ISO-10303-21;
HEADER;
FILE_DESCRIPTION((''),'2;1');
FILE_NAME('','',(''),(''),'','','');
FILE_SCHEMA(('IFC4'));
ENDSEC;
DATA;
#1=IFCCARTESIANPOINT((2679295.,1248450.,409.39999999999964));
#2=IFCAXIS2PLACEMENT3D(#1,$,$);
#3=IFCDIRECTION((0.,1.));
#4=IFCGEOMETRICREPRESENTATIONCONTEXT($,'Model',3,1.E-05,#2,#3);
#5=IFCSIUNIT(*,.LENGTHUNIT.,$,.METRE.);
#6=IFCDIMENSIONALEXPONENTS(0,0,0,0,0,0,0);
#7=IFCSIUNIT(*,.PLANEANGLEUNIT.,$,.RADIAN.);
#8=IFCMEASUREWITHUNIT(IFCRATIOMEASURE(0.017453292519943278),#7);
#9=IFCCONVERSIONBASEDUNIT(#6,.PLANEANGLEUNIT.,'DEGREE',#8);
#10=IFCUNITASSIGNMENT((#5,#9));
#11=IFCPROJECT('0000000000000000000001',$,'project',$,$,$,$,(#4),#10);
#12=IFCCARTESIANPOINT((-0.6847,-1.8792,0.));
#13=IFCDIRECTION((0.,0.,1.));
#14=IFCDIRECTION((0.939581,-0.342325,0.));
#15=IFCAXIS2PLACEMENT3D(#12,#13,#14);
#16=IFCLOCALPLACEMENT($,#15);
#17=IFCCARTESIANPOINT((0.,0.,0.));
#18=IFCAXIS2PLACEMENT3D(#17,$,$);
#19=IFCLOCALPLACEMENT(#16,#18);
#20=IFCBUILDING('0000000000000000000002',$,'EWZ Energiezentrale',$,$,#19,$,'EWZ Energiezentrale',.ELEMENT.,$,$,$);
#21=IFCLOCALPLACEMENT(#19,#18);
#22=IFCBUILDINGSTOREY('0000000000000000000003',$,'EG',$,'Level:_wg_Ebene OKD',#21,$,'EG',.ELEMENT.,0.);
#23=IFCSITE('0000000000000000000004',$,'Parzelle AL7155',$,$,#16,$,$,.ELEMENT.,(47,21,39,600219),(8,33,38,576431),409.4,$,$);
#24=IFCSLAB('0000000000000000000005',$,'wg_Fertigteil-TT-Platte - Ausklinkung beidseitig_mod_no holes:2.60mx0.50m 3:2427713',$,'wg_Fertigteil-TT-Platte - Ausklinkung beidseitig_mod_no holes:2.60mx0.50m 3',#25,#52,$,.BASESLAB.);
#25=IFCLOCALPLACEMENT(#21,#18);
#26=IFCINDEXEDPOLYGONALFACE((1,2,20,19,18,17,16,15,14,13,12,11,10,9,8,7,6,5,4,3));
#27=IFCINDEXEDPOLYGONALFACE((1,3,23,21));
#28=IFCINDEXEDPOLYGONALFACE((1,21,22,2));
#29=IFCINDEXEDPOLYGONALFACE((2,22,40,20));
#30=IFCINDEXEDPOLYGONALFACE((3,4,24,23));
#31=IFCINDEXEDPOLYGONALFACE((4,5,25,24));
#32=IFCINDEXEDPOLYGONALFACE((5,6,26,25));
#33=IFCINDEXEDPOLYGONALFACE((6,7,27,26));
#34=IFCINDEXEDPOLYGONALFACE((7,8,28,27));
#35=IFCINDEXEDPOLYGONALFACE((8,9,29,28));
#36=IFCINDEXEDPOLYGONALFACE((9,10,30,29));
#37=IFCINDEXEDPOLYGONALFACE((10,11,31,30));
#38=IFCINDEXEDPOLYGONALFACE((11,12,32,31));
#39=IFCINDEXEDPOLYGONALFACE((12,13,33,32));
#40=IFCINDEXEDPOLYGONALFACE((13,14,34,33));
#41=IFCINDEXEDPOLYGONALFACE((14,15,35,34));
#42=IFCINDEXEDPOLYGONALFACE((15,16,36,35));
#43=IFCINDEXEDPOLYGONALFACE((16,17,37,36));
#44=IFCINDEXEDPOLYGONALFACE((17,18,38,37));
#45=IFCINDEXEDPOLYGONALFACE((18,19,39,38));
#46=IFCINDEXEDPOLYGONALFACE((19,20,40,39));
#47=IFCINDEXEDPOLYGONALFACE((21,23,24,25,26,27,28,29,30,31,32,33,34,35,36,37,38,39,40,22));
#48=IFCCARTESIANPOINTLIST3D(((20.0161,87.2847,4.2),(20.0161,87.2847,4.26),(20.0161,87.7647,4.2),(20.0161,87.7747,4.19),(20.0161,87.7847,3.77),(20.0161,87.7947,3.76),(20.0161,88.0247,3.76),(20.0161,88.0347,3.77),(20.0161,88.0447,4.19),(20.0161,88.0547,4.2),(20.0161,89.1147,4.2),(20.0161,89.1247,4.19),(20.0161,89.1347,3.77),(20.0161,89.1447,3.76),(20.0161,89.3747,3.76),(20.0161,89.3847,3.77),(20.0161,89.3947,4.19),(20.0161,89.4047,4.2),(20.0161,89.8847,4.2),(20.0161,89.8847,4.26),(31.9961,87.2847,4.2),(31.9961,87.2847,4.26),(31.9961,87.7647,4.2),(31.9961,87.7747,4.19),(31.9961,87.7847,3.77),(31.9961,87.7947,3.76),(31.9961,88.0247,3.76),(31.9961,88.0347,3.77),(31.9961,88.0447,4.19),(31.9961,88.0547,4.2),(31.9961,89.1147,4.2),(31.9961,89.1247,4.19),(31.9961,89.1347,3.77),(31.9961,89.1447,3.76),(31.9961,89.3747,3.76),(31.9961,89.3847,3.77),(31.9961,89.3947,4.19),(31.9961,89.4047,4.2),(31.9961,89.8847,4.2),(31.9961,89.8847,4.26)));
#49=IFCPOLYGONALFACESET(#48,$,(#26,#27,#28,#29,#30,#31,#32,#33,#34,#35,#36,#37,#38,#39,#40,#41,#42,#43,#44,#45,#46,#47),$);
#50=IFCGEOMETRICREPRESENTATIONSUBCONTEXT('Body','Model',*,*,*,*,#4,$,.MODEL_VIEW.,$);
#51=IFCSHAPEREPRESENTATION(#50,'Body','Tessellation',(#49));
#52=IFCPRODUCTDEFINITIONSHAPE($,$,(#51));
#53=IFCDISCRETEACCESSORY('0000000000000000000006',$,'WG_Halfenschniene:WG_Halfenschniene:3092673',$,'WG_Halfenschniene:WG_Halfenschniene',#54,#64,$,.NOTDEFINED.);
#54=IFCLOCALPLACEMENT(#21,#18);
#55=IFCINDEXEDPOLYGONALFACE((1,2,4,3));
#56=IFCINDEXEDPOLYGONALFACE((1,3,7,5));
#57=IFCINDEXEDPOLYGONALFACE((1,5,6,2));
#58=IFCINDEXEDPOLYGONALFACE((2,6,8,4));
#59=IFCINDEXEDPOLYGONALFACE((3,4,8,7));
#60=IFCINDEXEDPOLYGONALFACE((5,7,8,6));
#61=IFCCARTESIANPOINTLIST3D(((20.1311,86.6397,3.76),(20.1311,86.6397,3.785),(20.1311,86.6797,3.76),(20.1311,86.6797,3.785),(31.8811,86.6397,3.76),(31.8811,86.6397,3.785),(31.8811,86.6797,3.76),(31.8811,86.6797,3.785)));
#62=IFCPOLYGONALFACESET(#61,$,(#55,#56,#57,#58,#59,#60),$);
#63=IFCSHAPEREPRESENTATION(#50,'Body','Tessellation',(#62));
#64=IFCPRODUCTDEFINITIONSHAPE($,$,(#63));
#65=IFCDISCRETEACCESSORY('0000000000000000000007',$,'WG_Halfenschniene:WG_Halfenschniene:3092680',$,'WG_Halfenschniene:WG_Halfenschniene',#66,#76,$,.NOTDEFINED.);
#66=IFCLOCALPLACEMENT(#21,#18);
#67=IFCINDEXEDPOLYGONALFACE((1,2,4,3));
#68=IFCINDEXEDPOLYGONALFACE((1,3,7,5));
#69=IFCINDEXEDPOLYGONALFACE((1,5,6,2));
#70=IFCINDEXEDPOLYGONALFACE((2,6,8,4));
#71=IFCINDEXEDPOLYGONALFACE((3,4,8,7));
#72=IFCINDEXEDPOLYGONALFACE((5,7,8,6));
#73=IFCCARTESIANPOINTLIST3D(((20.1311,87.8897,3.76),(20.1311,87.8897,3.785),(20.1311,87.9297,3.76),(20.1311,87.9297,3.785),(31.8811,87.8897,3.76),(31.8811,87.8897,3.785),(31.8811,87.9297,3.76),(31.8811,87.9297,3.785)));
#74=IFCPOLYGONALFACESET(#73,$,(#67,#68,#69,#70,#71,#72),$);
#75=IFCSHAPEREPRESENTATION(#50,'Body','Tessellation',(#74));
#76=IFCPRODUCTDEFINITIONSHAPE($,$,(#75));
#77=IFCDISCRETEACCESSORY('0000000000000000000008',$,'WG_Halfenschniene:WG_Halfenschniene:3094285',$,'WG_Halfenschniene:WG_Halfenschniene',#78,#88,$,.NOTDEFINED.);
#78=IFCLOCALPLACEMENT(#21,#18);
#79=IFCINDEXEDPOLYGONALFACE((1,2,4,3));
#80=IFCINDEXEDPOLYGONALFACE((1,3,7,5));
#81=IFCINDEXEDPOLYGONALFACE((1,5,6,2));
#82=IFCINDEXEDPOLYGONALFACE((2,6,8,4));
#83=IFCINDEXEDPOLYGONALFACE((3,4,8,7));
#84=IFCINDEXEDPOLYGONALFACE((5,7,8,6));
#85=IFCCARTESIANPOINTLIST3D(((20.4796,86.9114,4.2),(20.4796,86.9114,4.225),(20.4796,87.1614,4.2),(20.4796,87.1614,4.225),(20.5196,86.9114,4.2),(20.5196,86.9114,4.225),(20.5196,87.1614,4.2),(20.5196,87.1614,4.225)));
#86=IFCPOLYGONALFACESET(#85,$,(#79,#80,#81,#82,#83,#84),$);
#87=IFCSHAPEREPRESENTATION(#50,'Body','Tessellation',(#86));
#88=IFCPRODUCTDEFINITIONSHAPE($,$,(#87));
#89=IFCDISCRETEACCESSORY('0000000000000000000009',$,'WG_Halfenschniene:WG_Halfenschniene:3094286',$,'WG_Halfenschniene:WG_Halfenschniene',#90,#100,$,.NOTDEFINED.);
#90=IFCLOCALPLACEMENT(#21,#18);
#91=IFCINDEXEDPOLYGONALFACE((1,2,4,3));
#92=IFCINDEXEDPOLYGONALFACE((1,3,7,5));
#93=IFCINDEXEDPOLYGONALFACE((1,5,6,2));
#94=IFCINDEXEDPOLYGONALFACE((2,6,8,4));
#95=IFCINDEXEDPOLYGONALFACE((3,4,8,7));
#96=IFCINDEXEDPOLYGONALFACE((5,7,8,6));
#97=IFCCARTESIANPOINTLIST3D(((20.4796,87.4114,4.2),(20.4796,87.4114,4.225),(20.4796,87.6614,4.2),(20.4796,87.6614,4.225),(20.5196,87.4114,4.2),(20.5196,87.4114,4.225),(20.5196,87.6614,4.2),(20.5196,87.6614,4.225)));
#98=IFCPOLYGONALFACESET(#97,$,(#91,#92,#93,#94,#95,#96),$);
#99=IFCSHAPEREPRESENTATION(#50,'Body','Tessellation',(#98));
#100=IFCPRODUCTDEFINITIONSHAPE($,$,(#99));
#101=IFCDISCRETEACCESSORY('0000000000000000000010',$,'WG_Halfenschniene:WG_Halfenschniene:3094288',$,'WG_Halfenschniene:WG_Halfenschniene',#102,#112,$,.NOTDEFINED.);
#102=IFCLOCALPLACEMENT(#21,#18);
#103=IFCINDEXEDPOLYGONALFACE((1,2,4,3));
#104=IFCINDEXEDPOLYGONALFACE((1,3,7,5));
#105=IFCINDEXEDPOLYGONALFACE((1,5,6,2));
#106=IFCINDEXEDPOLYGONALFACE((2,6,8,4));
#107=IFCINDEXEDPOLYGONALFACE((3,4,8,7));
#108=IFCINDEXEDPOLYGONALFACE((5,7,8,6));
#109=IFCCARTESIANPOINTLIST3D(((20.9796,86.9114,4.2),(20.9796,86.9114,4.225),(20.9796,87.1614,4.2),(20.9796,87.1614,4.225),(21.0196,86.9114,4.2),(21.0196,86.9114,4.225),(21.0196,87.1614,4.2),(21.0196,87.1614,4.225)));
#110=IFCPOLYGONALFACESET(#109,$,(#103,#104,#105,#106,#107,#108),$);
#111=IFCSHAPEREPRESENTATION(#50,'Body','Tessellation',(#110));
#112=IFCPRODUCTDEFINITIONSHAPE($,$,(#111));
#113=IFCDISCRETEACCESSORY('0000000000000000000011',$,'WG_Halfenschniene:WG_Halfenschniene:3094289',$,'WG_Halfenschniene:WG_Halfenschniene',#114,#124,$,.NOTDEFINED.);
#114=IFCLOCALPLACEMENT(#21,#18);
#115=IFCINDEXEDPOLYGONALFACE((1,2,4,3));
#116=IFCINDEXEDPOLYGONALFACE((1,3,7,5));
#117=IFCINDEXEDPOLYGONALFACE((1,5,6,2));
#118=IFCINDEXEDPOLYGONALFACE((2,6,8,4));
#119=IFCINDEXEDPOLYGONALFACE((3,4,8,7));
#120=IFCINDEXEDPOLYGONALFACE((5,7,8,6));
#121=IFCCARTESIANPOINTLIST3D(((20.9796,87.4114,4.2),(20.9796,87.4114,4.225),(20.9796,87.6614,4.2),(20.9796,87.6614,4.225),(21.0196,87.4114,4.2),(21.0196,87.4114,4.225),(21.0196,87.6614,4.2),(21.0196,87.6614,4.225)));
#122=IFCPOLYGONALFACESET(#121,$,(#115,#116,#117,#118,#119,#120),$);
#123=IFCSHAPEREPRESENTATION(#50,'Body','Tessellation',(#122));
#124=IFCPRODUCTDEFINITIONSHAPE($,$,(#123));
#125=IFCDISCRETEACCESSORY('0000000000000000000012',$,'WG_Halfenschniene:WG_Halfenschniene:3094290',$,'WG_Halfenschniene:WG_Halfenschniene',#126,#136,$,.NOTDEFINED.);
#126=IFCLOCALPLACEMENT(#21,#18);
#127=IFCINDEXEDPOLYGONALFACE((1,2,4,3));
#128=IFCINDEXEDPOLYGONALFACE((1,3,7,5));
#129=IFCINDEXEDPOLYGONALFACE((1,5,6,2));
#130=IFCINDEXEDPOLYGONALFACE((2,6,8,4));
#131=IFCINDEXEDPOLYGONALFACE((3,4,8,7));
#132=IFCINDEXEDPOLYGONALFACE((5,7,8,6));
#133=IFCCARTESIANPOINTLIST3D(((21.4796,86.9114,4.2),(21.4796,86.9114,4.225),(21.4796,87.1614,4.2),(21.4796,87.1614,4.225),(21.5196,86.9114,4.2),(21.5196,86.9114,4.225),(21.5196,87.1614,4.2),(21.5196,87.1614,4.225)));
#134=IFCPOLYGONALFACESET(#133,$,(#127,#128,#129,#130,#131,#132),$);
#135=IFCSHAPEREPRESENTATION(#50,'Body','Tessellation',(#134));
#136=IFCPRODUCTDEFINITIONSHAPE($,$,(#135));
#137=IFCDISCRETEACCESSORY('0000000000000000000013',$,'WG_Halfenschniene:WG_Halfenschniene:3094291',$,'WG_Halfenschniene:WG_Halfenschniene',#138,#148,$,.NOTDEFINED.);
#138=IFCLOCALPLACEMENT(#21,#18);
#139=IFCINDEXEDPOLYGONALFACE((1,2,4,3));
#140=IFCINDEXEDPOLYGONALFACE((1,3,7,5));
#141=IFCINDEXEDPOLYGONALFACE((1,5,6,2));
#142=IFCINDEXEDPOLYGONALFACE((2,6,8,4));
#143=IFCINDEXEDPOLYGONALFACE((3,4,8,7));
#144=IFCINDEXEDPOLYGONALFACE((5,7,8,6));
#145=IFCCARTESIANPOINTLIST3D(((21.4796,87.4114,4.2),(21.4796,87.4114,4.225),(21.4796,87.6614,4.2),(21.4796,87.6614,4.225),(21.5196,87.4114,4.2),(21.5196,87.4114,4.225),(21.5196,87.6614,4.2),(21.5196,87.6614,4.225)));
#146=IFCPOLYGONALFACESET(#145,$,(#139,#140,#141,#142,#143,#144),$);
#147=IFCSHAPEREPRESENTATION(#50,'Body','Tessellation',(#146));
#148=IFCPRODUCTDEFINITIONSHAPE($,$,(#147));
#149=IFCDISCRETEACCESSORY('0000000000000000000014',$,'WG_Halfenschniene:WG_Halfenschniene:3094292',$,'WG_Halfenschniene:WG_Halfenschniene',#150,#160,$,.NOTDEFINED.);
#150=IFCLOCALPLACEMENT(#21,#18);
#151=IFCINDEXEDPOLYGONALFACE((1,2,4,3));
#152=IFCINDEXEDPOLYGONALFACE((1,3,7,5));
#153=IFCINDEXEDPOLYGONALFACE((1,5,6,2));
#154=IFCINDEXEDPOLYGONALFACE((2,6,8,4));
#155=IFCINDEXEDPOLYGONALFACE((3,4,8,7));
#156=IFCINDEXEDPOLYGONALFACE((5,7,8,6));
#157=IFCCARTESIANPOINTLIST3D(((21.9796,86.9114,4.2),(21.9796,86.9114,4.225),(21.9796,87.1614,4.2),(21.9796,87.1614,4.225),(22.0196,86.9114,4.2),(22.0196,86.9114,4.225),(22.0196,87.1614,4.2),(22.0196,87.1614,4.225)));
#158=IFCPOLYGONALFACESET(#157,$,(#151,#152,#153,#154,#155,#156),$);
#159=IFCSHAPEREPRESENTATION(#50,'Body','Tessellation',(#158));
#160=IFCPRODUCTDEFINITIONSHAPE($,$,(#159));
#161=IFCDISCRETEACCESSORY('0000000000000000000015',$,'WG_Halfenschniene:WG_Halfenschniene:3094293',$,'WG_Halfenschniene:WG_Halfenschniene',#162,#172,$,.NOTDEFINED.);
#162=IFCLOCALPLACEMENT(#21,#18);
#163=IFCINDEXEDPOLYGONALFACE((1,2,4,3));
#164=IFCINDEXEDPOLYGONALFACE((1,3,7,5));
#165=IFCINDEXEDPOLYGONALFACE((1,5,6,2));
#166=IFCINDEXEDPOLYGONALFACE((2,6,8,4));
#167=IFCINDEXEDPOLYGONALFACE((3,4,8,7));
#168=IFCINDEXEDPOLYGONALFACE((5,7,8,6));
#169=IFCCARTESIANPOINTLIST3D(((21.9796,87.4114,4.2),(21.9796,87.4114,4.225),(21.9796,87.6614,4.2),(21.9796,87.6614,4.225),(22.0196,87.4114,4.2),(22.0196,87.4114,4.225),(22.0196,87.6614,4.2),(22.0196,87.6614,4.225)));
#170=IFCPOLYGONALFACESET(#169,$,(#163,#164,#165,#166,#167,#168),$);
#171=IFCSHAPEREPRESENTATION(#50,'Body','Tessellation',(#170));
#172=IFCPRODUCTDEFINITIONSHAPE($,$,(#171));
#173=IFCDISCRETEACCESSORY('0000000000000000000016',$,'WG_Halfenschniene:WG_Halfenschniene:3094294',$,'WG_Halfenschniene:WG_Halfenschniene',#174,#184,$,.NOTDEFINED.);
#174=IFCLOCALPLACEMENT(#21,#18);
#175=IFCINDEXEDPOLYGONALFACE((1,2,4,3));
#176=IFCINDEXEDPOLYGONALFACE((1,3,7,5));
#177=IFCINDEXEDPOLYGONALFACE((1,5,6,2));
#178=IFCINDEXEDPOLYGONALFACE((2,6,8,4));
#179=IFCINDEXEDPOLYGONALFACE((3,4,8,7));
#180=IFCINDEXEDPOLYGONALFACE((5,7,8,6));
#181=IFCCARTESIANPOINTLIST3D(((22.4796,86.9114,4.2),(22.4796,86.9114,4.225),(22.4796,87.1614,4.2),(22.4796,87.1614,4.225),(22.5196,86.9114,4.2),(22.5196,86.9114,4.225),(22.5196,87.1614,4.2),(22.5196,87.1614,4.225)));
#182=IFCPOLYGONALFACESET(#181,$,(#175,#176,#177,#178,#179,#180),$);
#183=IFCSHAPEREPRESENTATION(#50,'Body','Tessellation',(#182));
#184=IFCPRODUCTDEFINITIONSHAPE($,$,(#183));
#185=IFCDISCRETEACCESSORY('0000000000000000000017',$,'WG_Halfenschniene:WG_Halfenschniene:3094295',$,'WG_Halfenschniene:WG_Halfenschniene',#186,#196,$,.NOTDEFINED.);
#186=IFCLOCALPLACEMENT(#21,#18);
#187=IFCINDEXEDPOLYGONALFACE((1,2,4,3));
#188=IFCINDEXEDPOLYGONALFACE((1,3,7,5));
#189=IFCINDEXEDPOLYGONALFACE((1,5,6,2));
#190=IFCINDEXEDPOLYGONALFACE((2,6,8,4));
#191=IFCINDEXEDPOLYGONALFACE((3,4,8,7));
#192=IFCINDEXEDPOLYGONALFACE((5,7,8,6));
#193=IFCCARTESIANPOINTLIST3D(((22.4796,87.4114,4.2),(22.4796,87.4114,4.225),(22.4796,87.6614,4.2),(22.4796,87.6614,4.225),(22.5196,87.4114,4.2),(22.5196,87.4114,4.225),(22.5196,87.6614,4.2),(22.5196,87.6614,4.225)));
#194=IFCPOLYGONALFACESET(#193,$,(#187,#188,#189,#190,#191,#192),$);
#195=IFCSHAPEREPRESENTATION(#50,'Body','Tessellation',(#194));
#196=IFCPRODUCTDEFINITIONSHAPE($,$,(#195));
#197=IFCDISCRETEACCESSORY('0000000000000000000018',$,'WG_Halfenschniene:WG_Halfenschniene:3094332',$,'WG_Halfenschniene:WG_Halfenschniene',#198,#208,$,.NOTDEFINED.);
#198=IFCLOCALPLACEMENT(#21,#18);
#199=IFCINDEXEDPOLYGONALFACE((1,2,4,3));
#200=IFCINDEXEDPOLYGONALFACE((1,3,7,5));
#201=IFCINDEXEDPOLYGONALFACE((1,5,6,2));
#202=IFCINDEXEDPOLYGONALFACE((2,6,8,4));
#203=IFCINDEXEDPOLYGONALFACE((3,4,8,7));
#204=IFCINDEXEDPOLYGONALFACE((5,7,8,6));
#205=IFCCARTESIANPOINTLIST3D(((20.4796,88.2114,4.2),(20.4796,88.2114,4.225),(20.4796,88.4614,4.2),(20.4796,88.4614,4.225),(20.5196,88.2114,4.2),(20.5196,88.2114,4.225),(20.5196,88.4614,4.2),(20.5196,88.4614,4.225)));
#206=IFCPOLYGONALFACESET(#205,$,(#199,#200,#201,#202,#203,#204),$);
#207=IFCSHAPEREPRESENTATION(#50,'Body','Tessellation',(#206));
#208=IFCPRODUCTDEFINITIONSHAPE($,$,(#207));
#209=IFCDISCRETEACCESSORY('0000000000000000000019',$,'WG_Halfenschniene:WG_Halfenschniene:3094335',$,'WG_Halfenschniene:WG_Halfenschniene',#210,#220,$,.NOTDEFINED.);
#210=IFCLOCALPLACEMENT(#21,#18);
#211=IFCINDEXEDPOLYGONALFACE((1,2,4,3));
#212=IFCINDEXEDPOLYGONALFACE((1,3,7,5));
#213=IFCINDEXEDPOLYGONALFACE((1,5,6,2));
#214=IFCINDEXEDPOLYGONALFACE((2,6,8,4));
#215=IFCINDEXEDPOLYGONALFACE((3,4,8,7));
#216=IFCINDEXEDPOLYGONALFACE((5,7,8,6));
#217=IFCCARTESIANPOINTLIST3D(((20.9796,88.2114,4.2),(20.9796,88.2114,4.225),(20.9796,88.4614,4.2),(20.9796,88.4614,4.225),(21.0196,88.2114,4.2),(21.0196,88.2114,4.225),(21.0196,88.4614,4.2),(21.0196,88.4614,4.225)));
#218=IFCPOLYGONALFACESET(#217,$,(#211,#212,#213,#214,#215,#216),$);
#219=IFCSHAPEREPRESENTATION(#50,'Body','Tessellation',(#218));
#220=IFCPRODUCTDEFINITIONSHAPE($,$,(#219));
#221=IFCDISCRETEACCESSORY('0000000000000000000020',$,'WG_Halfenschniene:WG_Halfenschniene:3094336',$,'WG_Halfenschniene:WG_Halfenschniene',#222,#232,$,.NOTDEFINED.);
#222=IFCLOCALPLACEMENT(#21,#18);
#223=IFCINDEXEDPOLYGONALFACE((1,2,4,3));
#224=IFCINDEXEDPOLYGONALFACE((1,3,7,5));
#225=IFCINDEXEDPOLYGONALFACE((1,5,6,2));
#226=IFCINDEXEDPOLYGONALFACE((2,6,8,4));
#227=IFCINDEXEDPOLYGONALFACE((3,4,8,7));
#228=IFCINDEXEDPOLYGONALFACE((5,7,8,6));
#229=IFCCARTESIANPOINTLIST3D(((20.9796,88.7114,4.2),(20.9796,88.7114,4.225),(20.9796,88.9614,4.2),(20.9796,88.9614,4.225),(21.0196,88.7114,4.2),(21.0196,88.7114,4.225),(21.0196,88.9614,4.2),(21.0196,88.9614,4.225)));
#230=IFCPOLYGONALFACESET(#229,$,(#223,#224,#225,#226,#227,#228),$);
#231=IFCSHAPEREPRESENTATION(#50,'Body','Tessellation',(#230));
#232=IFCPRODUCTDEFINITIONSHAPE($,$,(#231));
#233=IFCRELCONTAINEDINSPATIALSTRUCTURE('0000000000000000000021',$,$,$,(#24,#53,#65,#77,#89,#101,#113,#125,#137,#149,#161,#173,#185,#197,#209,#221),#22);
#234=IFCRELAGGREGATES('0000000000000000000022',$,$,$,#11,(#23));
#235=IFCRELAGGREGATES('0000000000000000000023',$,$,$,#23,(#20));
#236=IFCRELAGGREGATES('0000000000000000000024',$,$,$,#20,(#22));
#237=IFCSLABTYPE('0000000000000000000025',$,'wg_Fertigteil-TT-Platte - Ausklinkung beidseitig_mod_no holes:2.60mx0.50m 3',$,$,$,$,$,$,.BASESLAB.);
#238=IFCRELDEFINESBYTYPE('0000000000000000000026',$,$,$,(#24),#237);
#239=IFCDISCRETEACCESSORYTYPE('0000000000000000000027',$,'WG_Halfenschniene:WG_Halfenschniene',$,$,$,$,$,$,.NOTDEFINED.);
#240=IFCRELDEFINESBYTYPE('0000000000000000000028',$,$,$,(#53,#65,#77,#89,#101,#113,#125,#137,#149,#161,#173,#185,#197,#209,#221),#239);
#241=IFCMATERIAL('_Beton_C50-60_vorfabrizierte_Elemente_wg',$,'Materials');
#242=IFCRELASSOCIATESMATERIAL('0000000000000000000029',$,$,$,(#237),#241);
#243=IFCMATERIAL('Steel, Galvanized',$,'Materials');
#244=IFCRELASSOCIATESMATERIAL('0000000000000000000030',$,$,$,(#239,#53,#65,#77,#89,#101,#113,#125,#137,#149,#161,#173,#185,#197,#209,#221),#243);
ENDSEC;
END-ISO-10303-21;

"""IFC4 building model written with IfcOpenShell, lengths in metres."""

from ifc_helpers import new_model, entity, si_unit, converted_unit, direction, frame, origin, place, context, subcontext, project, spatial, indexed_curve, outline, extrude, source, transform, mapped, material, type_object, type_shapes, element, save


model = new_model("IFC4")

# Units and contexts
model_context = context("Model", 3, precision=1e-05, world=frame((2679295.0, 1248450.0, 409.39999999999964)), true_north=direction((0.0, 1.0)))
body_context = subcontext(model_context, "Body", "Model", "MODEL_VIEW")
ifc_project = project(units=[si_unit("LENGTHUNIT", "METRE"), converted_unit("PLANEANGLEUNIT", "DEGREE", entity("IfcRatioMeasure", 0.017453292519943278), si_unit("PLANEANGLEUNIT", "RADIAN"), dimensions=[0, 0, 0, 0, 0, 0, 0])], contexts=[model_context])

# Site, building, storey
site_placement = place(None, frame((-0.6847, -1.8792, 0.0), z_axis=(0.0, 0.0, 1.0), x_axis=(0.939581, -0.342325, 0.0)))
site = spatial("IfcSite", under=ifc_project, at=site_placement, Name="Parzelle AL7155", CompositionType="ELEMENT", RefLatitude=(47, 21, 39, 600219), RefLongitude=(8, 33, 38, 576431), RefElevation=409.4)
building_placement = place(site_placement, origin())
building = spatial("IfcBuilding", under=site, at=building_placement, Name="EWZ Energiezentrale", LongName="EWZ Energiezentrale", CompositionType="ELEMENT")
storey_placement = place(building_placement, origin())
storey = spatial("IfcBuildingStorey", under=building, at=storey_placement, Name="EG", ObjectType="Level:_wg_Ebene OKD", LongName="EG", CompositionType="ELEMENT", Elevation=0.0)

# Slab
ifc_material_1 = material(Name="_Beton_C50-60_vorfabrizierte_Elemente_wg", Category="Materials")
slab_type = type_object("IfcSlabType", Name="wg_Fertigteil-TT-Platte - Ausklinkung beidseitig_mod_no holes:2.60mx0.50m 3", PredefinedType="BASESLAB", material=ifc_material_1)
slab_placement = place(storey_placement, frame((20.0161, 87.2847, 3.76), z_axis=(0.0, 0.0, 1.0), x_axis=(1.0, 0.0, 0.0)))
element("IfcSlab", 1, at=slab_placement, inside=storey, type_object=slab_type, Name="wg_Fertigteil-TT-Platte - Ausklinkung beidseitig_mod_no holes:2.60mx0.50m 3:2427713", ObjectType="wg_Fertigteil-TT-Platte - Ausklinkung beidseitig_mod_no holes:2.60mx0.50m 3", PredefinedType="BASESLAB", context=body_context, shape_type="SweptSolid", body=[
    extrude(outline(indexed_curve([(-1.3, -0.23), (1.3, -0.23), (1.3, -0.17), (0.82, -0.17), (0.81, -0.16), (0.8, 0.26), (0.79, 0.27), (0.56, 0.27), (0.55, 0.26), (0.54, -0.16), (0.53, -0.17), (-0.53, -0.17), (-0.54, -0.16), (-0.55, 0.26), (-0.56, 0.27), (-0.79, 0.27), (-0.8, 0.26), (-0.81, -0.16), (-0.82, -0.17), (-1.3, -0.17), (-1.3, -0.23)], self_intersect=False)), frame((0.0, 1.3, 0.27), z_axis=(1.0, 0.0, 0.0), x_axis=(0.0, -1.0, 0.0)), (0.0, 0.0, 1.0), 11.98),
])

# Discrete accessories
ifc_material_2 = material(Name="Steel, Galvanized", Category="Materials")
discrete_accessory_type = type_object("IfcDiscreteAccessoryType", Name="WG_Halfenschniene:WG_Halfenschniene", PredefinedType="NOTDEFINED", material=ifc_material_2)
shared_shape_1 = source(origin(), body_context, "Body", "SweptSolid", [
    extrude(outline(indexed_curve([(-5.875, -0.02), (5.875, -0.02), (5.875, 0.02), (-5.875, 0.02), (-5.875, -0.02)], self_intersect=False)), frame((5.875, 0.0, -0.0125)), (0.0, 0.0, 1.0), 0.025),
])
type_shapes(discrete_accessory_type, [shared_shape_1])
for number, where, z_axis, x_axis, name in (
    (2, (20.1311, 86.6597, 3.7725), (0.0, 0.0, -1.0), (1.0, 0.0, 0.0), "WG_Halfenschniene:WG_Halfenschniene:3092673"),
    (3, (20.1311, 87.9097, 3.7725), (0.0, 0.0, -1.0), (1.0, 0.0, 0.0), "WG_Halfenschniene:WG_Halfenschniene:3092680"),
):
    element("IfcDiscreteAccessory", number, at=place(storey_placement, frame(where, z_axis=z_axis, x_axis=x_axis)), inside=storey, type_object=discrete_accessory_type, material=ifc_material_2, Name=name, ObjectType="WG_Halfenschniene:WG_Halfenschniene", PredefinedType="NOTDEFINED", context=body_context, shape_type="MappedRepresentation", body=[
        mapped(shared_shape_1, transform((0.0, 0.0, 0.0), scale=1.0)),
    ])
shared_shape_2 = source(origin(), body_context, "Body", "SweptSolid", [
    extrude(outline(indexed_curve([(-0.125, -0.02), (0.125, -0.02), (0.125, 0.02), (-0.125, 0.02), (-0.125, -0.02)], self_intersect=False)), frame((0.125, 0.0, -0.0125)), (0.0, 0.0, 1.0), 0.025),
])
for number, where, z_axis, x_axis, name in (
    (4, (20.4996, 86.9114, 4.2125), (0.0, 0.0, -1.0), (0.0, 1.0, 0.0), "WG_Halfenschniene:WG_Halfenschniene:3094285"),
    (5, (20.4996, 87.4114, 4.2125), (0.0, 0.0, -1.0), (0.0, 1.0, 0.0), "WG_Halfenschniene:WG_Halfenschniene:3094286"),
    (6, (20.9996, 86.9114, 4.2125), (0.0, 0.0, -1.0), (0.0, 1.0, 0.0), "WG_Halfenschniene:WG_Halfenschniene:3094288"),
    (7, (20.9996, 87.4114, 4.2125), (0.0, 0.0, -1.0), (0.0, 1.0, 0.0), "WG_Halfenschniene:WG_Halfenschniene:3094289"),
    (8, (21.4996, 86.9114, 4.2125), (0.0, 0.0, -1.0), (0.0, 1.0, 0.0), "WG_Halfenschniene:WG_Halfenschniene:3094290"),
    (9, (21.4996, 87.4114, 4.2125), (0.0, 0.0, -1.0), (0.0, 1.0, 0.0), "WG_Halfenschniene:WG_Halfenschniene:3094291"),
    (10, (21.9996, 86.9114, 4.2125), (0.0, 0.0, -1.0), (0.0, 1.0, 0.0), "WG_Halfenschniene:WG_Halfenschniene:3094292"),
    (11, (21.9996, 87.4114, 4.2125), (0.0, 0.0, -1.0), (0.0, 1.0, 0.0), "WG_Halfenschniene:WG_Halfenschniene:3094293"),
    (12, (22.4996, 86.9114, 4.2125), (0.0, 0.0, -1.0), (0.0, 1.0, 0.0), "WG_Halfenschniene:WG_Halfenschniene:3094294"),
    (13, (22.4996, 87.4114, 4.2125), (0.0, 0.0, -1.0), (0.0, 1.0, 0.0), "WG_Halfenschniene:WG_Halfenschniene:3094295"),
    (14, (20.4996, 88.2114, 4.2125), (0.0, 0.0, -1.0), (0.0, 1.0, 0.0), "WG_Halfenschniene:WG_Halfenschniene:3094332"),
    (15, (20.9996, 88.2114, 4.2125), (0.0, 0.0, -1.0), (0.0, 1.0, 0.0), "WG_Halfenschniene:WG_Halfenschniene:3094335"),
    (16, (20.9996, 88.7114, 4.2125), (0.0, 0.0, -1.0), (0.0, 1.0, 0.0), "WG_Halfenschniene:WG_Halfenschniene:3094336"),
):
    element("IfcDiscreteAccessory", number, at=place(storey_placement, frame(where, z_axis=z_axis, x_axis=x_axis)), inside=storey, type_object=discrete_accessory_type, material=ifc_material_2, Name=name, ObjectType="WG_Halfenschniene:WG_Halfenschniene", PredefinedType="NOTDEFINED", context=body_context, shape_type="MappedRepresentation", body=[
        mapped(shared_shape_2, transform((0.0, 0.0, 0.0), scale=1.0)),
    ])

save(model, "model.ifc")
